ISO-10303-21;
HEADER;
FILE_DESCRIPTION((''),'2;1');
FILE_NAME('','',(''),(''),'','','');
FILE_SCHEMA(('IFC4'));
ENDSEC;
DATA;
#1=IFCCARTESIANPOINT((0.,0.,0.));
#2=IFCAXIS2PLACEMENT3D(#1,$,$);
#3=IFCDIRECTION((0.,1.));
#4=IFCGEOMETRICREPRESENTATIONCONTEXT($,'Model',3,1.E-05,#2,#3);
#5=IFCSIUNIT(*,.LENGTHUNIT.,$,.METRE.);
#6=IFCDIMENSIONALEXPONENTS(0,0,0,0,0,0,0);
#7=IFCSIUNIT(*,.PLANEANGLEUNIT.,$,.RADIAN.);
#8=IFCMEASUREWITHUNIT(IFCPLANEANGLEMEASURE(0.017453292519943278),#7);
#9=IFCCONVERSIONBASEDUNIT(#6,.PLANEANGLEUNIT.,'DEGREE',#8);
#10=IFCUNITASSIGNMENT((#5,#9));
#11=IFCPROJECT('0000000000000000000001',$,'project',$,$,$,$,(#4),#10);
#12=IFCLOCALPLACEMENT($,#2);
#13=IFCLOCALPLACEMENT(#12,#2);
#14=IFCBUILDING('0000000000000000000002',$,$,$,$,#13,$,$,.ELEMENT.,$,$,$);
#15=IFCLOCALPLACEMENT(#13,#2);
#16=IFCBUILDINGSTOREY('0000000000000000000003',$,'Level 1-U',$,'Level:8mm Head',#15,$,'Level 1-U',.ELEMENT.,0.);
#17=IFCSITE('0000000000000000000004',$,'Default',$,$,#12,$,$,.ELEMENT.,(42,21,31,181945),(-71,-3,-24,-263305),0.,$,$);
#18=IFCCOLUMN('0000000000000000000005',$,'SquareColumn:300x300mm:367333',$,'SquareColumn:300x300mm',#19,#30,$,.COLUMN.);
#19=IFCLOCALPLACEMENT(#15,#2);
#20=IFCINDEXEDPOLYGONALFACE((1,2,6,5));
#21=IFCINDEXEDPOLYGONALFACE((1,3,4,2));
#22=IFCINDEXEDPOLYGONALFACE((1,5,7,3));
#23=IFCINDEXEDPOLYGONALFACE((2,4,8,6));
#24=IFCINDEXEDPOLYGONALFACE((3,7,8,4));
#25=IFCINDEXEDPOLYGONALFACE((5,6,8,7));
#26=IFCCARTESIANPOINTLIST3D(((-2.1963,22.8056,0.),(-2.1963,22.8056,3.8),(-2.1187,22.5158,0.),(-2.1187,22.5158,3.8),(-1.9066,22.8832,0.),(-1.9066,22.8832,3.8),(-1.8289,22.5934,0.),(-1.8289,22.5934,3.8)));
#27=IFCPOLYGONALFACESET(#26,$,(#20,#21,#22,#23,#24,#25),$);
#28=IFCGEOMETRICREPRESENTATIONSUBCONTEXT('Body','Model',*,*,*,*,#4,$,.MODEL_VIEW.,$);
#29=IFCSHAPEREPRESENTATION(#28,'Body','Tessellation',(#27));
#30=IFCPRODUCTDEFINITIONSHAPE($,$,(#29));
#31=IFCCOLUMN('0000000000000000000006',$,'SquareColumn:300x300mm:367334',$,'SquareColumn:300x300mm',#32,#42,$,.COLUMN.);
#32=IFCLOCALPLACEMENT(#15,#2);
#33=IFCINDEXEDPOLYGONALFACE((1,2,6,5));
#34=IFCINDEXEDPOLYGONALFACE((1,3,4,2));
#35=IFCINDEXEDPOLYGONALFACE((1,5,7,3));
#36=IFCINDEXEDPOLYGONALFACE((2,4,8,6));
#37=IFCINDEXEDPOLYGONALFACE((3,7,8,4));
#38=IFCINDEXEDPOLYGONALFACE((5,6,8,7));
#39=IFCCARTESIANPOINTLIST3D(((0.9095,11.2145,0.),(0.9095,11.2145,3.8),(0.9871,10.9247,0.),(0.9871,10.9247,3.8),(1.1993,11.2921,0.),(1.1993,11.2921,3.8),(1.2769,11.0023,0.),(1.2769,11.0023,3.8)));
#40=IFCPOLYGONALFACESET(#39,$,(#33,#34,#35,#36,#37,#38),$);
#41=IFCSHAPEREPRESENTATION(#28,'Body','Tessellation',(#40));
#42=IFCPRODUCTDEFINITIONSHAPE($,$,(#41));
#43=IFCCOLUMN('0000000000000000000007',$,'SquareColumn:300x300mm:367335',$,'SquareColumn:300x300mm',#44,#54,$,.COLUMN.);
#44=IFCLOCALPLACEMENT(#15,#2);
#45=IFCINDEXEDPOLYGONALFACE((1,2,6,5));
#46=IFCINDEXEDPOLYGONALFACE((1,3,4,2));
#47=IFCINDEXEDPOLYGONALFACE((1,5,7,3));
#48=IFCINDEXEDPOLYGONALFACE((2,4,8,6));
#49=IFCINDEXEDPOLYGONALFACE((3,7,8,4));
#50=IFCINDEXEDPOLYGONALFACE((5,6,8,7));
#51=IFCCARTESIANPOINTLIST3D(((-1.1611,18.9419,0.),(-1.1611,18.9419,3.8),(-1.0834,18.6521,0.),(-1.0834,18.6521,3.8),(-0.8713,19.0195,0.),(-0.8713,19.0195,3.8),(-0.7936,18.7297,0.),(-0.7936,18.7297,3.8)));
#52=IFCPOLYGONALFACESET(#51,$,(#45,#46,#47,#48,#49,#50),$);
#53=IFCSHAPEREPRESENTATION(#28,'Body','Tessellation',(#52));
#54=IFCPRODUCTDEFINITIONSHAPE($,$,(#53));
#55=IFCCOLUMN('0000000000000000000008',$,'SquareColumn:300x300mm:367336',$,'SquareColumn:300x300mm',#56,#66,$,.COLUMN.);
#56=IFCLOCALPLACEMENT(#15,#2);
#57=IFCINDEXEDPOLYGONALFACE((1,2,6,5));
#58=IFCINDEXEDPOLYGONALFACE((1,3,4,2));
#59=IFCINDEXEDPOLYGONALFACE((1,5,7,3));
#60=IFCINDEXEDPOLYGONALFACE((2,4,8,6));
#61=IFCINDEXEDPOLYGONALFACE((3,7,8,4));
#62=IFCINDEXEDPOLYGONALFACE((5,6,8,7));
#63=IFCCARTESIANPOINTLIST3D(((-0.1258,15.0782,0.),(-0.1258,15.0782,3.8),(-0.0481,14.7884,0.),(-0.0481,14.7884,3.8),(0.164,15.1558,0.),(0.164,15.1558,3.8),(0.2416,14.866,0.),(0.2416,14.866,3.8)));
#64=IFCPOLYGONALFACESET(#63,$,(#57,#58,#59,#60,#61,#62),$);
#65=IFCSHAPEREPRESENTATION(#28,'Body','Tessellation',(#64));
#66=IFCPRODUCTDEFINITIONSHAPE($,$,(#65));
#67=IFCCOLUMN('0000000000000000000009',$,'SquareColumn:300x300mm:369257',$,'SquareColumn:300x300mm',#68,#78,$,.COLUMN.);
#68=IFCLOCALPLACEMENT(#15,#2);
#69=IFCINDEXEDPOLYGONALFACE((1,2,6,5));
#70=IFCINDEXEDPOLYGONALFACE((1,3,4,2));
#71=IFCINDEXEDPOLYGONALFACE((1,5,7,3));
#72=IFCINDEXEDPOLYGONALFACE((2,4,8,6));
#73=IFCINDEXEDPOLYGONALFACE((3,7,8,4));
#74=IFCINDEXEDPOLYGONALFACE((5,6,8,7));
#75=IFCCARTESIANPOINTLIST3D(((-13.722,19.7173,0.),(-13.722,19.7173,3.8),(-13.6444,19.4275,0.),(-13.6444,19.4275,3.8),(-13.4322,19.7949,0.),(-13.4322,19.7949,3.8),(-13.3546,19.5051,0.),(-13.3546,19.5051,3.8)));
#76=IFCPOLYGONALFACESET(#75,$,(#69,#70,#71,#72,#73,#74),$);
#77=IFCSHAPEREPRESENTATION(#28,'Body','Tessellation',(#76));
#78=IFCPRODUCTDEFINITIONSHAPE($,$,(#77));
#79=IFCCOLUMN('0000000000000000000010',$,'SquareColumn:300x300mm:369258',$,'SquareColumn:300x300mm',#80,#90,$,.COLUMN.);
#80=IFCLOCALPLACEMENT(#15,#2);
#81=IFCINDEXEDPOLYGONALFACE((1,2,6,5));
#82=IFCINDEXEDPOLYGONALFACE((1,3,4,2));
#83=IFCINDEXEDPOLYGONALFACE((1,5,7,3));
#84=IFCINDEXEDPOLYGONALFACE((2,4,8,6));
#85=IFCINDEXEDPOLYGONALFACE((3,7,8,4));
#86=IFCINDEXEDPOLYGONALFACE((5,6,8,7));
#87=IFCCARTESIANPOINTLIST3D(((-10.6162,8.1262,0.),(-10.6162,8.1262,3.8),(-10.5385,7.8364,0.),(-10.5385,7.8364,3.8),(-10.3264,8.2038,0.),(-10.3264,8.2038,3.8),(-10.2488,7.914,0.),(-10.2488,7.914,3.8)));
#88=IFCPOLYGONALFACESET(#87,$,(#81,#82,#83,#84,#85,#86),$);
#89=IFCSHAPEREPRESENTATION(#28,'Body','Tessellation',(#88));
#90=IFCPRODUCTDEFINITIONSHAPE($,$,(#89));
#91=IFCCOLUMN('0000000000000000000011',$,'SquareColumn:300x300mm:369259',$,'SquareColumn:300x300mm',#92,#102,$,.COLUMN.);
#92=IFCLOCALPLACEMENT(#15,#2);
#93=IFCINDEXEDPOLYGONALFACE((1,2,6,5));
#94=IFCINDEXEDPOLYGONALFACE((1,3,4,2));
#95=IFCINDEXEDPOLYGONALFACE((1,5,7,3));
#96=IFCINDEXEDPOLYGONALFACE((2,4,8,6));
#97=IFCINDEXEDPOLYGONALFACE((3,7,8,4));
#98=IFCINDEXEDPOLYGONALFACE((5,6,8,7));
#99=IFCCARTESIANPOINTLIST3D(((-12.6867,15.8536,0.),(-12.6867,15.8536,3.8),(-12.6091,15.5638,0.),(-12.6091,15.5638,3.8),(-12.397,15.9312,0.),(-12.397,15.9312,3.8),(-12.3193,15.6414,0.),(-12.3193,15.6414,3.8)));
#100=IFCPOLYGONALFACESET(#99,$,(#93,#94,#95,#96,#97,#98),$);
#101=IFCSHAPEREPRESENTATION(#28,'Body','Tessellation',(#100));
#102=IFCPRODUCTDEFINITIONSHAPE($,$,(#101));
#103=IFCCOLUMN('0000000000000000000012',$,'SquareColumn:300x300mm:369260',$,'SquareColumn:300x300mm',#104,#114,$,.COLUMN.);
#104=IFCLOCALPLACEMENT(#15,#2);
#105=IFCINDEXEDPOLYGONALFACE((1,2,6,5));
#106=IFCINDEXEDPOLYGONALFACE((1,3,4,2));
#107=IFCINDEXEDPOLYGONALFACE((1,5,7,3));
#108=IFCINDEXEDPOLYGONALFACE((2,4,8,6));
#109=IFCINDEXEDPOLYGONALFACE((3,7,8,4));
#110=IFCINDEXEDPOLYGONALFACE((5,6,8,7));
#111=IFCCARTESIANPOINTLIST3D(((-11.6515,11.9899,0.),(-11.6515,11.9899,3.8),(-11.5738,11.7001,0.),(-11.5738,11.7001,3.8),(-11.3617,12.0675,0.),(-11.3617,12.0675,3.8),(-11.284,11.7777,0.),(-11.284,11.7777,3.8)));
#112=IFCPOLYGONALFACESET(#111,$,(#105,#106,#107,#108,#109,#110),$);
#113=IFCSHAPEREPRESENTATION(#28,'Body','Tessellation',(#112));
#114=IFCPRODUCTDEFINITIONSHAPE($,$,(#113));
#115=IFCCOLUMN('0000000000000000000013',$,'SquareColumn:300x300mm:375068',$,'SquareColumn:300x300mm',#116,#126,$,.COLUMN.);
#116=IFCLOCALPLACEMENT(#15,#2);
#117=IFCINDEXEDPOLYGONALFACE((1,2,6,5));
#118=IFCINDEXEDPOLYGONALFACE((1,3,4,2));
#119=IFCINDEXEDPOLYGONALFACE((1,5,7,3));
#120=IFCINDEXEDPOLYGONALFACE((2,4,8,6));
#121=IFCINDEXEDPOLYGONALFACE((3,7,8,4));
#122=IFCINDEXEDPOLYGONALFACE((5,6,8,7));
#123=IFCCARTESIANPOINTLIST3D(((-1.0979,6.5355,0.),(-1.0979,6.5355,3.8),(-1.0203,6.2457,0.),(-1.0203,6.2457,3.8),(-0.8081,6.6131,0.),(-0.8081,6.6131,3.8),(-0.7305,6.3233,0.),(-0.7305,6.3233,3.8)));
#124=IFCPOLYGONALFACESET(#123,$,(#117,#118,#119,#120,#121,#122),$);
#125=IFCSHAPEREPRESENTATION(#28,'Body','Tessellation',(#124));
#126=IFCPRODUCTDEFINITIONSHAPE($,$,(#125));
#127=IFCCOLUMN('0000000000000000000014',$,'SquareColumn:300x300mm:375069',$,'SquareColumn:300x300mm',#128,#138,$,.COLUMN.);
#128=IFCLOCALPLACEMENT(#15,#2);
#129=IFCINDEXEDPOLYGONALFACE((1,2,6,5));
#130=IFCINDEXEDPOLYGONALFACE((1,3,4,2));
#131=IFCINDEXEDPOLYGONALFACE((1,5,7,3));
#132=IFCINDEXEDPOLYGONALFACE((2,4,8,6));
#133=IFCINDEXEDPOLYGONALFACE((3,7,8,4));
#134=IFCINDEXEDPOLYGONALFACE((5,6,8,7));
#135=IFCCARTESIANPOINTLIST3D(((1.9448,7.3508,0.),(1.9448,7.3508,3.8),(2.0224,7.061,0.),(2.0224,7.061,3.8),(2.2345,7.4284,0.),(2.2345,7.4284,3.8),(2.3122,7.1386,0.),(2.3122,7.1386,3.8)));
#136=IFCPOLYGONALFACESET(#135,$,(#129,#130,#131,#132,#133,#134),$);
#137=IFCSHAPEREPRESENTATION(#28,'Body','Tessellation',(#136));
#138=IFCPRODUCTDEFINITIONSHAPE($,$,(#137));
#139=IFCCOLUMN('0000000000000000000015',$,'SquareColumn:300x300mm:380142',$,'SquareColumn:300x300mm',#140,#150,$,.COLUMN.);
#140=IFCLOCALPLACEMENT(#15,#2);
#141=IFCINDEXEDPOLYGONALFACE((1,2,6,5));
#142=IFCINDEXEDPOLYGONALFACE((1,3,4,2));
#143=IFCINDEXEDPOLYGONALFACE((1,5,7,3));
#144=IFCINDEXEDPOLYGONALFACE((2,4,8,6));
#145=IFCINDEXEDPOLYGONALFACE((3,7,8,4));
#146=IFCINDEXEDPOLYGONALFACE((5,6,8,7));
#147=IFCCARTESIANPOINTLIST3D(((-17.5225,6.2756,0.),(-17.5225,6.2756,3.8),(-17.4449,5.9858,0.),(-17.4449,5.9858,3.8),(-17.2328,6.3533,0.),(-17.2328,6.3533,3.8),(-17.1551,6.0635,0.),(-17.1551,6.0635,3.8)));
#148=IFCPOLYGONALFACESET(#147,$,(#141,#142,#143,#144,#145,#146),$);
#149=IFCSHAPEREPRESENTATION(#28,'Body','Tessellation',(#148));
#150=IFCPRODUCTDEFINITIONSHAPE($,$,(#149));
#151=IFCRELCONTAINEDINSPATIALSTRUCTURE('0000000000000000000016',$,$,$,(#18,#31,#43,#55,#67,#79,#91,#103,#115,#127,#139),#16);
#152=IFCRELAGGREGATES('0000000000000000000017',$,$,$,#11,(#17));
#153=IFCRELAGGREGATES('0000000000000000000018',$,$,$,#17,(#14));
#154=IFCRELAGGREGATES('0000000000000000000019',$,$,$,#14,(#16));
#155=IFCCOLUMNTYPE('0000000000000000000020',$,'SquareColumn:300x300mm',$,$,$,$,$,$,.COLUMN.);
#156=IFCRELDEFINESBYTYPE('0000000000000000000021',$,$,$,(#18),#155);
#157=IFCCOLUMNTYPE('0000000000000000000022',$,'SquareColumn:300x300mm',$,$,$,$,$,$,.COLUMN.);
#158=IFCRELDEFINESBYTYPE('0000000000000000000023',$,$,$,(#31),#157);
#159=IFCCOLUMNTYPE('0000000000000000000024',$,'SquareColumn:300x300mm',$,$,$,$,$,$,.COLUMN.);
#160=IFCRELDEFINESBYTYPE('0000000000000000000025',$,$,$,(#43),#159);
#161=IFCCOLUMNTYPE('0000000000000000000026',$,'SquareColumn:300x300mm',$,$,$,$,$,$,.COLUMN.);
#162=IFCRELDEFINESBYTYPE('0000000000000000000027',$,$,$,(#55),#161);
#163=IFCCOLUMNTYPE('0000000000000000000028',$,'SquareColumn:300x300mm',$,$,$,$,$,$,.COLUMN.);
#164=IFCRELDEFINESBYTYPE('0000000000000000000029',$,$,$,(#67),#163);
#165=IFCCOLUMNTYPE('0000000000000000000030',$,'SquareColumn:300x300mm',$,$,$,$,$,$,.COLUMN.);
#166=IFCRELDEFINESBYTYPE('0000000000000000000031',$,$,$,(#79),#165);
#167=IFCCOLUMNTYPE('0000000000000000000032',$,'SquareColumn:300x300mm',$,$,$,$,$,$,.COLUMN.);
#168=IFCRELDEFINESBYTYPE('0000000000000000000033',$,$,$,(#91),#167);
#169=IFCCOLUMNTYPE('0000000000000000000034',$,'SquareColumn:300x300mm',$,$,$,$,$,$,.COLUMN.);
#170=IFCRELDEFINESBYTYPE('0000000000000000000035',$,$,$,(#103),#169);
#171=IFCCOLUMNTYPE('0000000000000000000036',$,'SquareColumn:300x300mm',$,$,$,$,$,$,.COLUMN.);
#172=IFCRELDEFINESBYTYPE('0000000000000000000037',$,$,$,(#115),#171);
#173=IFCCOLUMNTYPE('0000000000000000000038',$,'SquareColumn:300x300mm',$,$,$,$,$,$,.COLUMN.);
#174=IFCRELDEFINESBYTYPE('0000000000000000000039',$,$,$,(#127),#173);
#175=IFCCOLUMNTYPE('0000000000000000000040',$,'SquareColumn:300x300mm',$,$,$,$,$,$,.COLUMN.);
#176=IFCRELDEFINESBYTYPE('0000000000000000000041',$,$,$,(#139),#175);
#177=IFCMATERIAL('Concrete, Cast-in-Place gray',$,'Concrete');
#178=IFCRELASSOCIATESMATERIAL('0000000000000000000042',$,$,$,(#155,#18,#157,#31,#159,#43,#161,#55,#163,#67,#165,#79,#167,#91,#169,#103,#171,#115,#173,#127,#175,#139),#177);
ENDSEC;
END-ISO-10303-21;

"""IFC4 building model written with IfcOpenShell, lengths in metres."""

from ifc_helpers import new_model, entity, si_unit, converted_unit, direction, frame, origin, place, context, subcontext, project, spatial, indexed_curve, outline, extrude, source, transform, mapped, material, type_object, type_shapes, element, save


model = new_model("IFC4")

# Units and contexts
model_context = context("Model", 3, precision=1e-05, world=origin(), true_north=direction((0.0, 1.0)))
body_context = subcontext(model_context, "Body", "Model", "MODEL_VIEW")
ifc_project = project(units=[si_unit("LENGTHUNIT", "METRE"), converted_unit("PLANEANGLEUNIT", "DEGREE", entity("IfcPlaneAngleMeasure", 0.017453292519943278), si_unit("PLANEANGLEUNIT", "RADIAN"), dimensions=[0, 0, 0, 0, 0, 0, 0])], contexts=[model_context])

# Site, building, storey
site_placement = place(None, origin())
site = spatial("IfcSite", under=ifc_project, at=site_placement, Name="Default", CompositionType="ELEMENT", RefLatitude=(42, 21, 31, 181945), RefLongitude=(-71, -3, -24, -263305), RefElevation=0.0)
building_placement = place(site_placement, origin())
building = spatial("IfcBuilding", under=site, at=building_placement, CompositionType="ELEMENT")
storey_placement = place(building_placement, origin())
storey = spatial("IfcBuildingStorey", under=building, at=storey_placement, Name="Level 1-U", ObjectType="Level:8mm Head", LongName="Level 1-U", CompositionType="ELEMENT", Elevation=0.0)

# Columns
ifc_material_1 = material(Name="Concrete, Cast-in-Place gray", Category="Concrete")
column_type_1 = type_object("IfcColumnType", Name="SquareColumn:300x300mm", PredefinedType="COLUMN", material=ifc_material_1)
shared_shape_1 = source(origin(), body_context, "Body", "SweptSolid", [
    extrude(outline(indexed_curve([(-0.15, -0.15), (0.15, -0.15), (0.15, 0.15), (-0.15, 0.15), (-0.15, -0.15)], self_intersect=False)), frame((-2.0126, 22.6995, 0.0), z_axis=(0.0, 0.0, 1.0), x_axis=(-0.258819, 0.965926, 0.0)), (0.0, 0.0, 1.0), 3.8),
])
type_shapes(column_type_1, [shared_shape_1])
column_1_placement = place(storey_placement, origin())
element("IfcColumn", 1, at=column_1_placement, inside=storey, type_object=column_type_1, material=ifc_material_1, Name="SquareColumn:300x300mm:367333", ObjectType="SquareColumn:300x300mm", PredefinedType="COLUMN", context=body_context, shape_type="MappedRepresentation", body=[
    mapped(shared_shape_1, transform((0.0, 0.0, 0.0), scale=1.0)),
])
column_type_2 = type_object("IfcColumnType", Name="SquareColumn:300x300mm", PredefinedType="COLUMN", material=ifc_material_1)
shared_shape_2 = source(origin(), body_context, "Body", "SweptSolid", [
    extrude(outline(indexed_curve([(-0.15, -0.15), (0.15, -0.15), (0.15, 0.15), (-0.15, 0.15), (-0.15, -0.15)], self_intersect=False)), frame((1.0932, 11.1084, 0.0), z_axis=(0.0, 0.0, 1.0), x_axis=(-0.258819, 0.965926, 0.0)), (0.0, 0.0, 1.0), 3.8),
])
type_shapes(column_type_2, [shared_shape_2])
column_2_placement = place(storey_placement, origin())
element("IfcColumn", 2, at=column_2_placement, inside=storey, type_object=column_type_2, material=ifc_material_1, Name="SquareColumn:300x300mm:367334", ObjectType="SquareColumn:300x300mm", PredefinedType="COLUMN", context=body_context, shape_type="MappedRepresentation", body=[
    mapped(shared_shape_2, transform((0.0, 0.0, 0.0), scale=1.0)),
])
column_type_3 = type_object("IfcColumnType", Name="SquareColumn:300x300mm", PredefinedType="COLUMN", material=ifc_material_1)
shared_shape_3 = source(origin(), body_context, "Body", "SweptSolid", [
    extrude(outline(indexed_curve([(-0.15, -0.15), (0.15, -0.15), (0.15, 0.15), (-0.15, 0.15), (-0.15, -0.15)], self_intersect=False)), frame((-0.9774, 18.8358, 0.0), z_axis=(0.0, 0.0, 1.0), x_axis=(-0.258819, 0.965926, 0.0)), (0.0, 0.0, 1.0), 3.8),
])
type_shapes(column_type_3, [shared_shape_3])
column_3_placement = place(storey_placement, origin())
element("IfcColumn", 3, at=column_3_placement, inside=storey, type_object=column_type_3, material=ifc_material_1, Name="SquareColumn:300x300mm:367335", ObjectType="SquareColumn:300x300mm", PredefinedType="COLUMN", context=body_context, shape_type="MappedRepresentation", body=[
    mapped(shared_shape_3, transform((0.0, 0.0, 0.0), scale=1.0)),
])
column_type_4 = type_object("IfcColumnType", Name="SquareColumn:300x300mm", PredefinedType="COLUMN", material=ifc_material_1)
shared_shape_4 = source(origin(), body_context, "Body", "SweptSolid", [
    extrude(outline(indexed_curve([(-0.15, -0.15), (0.15, -0.15), (0.15, 0.15), (-0.15, 0.15), (-0.15, -0.15)], self_intersect=False)), frame((0.0579, 14.9721, 0.0), z_axis=(0.0, 0.0, 1.0), x_axis=(-0.258819, 0.965926, 0.0)), (0.0, 0.0, 1.0), 3.8),
])
type_shapes(column_type_4, [shared_shape_4])
column_4_placement = place(storey_placement, origin())
element("IfcColumn", 4, at=column_4_placement, inside=storey, type_object=column_type_4, material=ifc_material_1, Name="SquareColumn:300x300mm:367336", ObjectType="SquareColumn:300x300mm", PredefinedType="COLUMN", context=body_context, shape_type="MappedRepresentation", body=[
    mapped(shared_shape_4, transform((0.0, 0.0, 0.0), scale=1.0)),
])
column_type_5 = type_object("IfcColumnType", Name="SquareColumn:300x300mm", PredefinedType="COLUMN", material=ifc_material_1)
shared_shape_5 = source(origin(), body_context, "Body", "SweptSolid", [
    extrude(outline(indexed_curve([(-0.15, -0.15), (0.15, -0.15), (0.15, 0.15), (-0.15, 0.15), (-0.15, -0.15)], self_intersect=False)), frame((-13.5383, 19.6112, 0.0), z_axis=(0.0, 0.0, 1.0), x_axis=(-0.258819, 0.965926, 0.0)), (0.0, 0.0, 1.0), 3.8),
])
type_shapes(column_type_5, [shared_shape_5])
column_5_placement = place(storey_placement, origin())
element("IfcColumn", 5, at=column_5_placement, inside=storey, type_object=column_type_5, material=ifc_material_1, Name="SquareColumn:300x300mm:369257", ObjectType="SquareColumn:300x300mm", PredefinedType="COLUMN", context=body_context, shape_type="MappedRepresentation", body=[
    mapped(shared_shape_5, transform((0.0, 0.0, 0.0), scale=1.0)),
])
column_type_6 = type_object("IfcColumnType", Name="SquareColumn:300x300mm", PredefinedType="COLUMN", material=ifc_material_1)
shared_shape_6 = source(origin(), body_context, "Body", "SweptSolid", [
    extrude(outline(indexed_curve([(-0.15, -0.15), (0.15, -0.15), (0.15, 0.15), (-0.15, 0.15), (-0.15, -0.15)], self_intersect=False)), frame((-10.4325, 8.0201, 0.0), z_axis=(0.0, 0.0, 1.0), x_axis=(-0.258819, 0.965926, 0.0)), (0.0, 0.0, 1.0), 3.8),
])
type_shapes(column_type_6, [shared_shape_6])
column_6_placement = place(storey_placement, origin())
element("IfcColumn", 6, at=column_6_placement, inside=storey, type_object=column_type_6, material=ifc_material_1, Name="SquareColumn:300x300mm:369258", ObjectType="SquareColumn:300x300mm", PredefinedType="COLUMN", context=body_context, shape_type="MappedRepresentation", body=[
    mapped(shared_shape_6, transform((0.0, 0.0, 0.0), scale=1.0)),
])
column_type_7 = type_object("IfcColumnType", Name="SquareColumn:300x300mm", PredefinedType="COLUMN", material=ifc_material_1)
shared_shape_7 = source(origin(), body_context, "Body", "SweptSolid", [
    extrude(outline(indexed_curve([(-0.15, -0.15), (0.15, -0.15), (0.15, 0.15), (-0.15, 0.15), (-0.15, -0.15)], self_intersect=False)), frame((-12.503, 15.7475, 0.0), z_axis=(0.0, 0.0, 1.0), x_axis=(-0.258819, 0.965926, 0.0)), (0.0, 0.0, 1.0), 3.8),
])
type_shapes(column_type_7, [shared_shape_7])
column_7_placement = place(storey_placement, origin())
element("IfcColumn", 7, at=column_7_placement, inside=storey, type_object=column_type_7, material=ifc_material_1, Name="SquareColumn:300x300mm:369259", ObjectType="SquareColumn:300x300mm", PredefinedType="COLUMN", context=body_context, shape_type="MappedRepresentation", body=[
    mapped(shared_shape_7, transform((0.0, 0.0, 0.0), scale=1.0)),
])
column_type_8 = type_object("IfcColumnType", Name="SquareColumn:300x300mm", PredefinedType="COLUMN", material=ifc_material_1)
shared_shape_8 = source(origin(), body_context, "Body", "SweptSolid", [
    extrude(outline(indexed_curve([(-0.15, -0.15), (0.15, -0.15), (0.15, 0.15), (-0.15, 0.15), (-0.15, -0.15)], self_intersect=False)), frame((-11.4677, 11.8838, 0.0), z_axis=(0.0, 0.0, 1.0), x_axis=(-0.258819, 0.965926, 0.0)), (0.0, 0.0, 1.0), 3.8),
])
type_shapes(column_type_8, [shared_shape_8])
column_8_placement = place(storey_placement, origin())
element("IfcColumn", 8, at=column_8_placement, inside=storey, type_object=column_type_8, material=ifc_material_1, Name="SquareColumn:300x300mm:369260", ObjectType="SquareColumn:300x300mm", PredefinedType="COLUMN", context=body_context, shape_type="MappedRepresentation", body=[
    mapped(shared_shape_8, transform((0.0, 0.0, 0.0), scale=1.0)),
])
column_type_9 = type_object("IfcColumnType", Name="SquareColumn:300x300mm", PredefinedType="COLUMN", material=ifc_material_1)
shared_shape_9 = source(origin(), body_context, "Body", "SweptSolid", [
    extrude(outline(indexed_curve([(-0.15, -0.15), (0.15, -0.15), (0.15, 0.15), (-0.15, 0.15), (-0.15, -0.15)], self_intersect=False)), frame((-0.9142, 6.4294, 0.0), z_axis=(0.0, 0.0, 1.0), x_axis=(-0.258819, 0.965926, 0.0)), (0.0, 0.0, 1.0), 3.8),
])
type_shapes(column_type_9, [shared_shape_9])
column_9_placement = place(storey_placement, origin())
element("IfcColumn", 9, at=column_9_placement, inside=storey, type_object=column_type_9, material=ifc_material_1, Name="SquareColumn:300x300mm:375068", ObjectType="SquareColumn:300x300mm", PredefinedType="COLUMN", context=body_context, shape_type="MappedRepresentation", body=[
    mapped(shared_shape_9, transform((0.0, 0.0, 0.0), scale=1.0)),
])
column_type_10 = type_object("IfcColumnType", Name="SquareColumn:300x300mm", PredefinedType="COLUMN", material=ifc_material_1)
shared_shape_10 = source(origin(), body_context, "Body", "SweptSolid", [
    extrude(outline(indexed_curve([(-0.15, -0.15), (0.15, -0.15), (0.15, 0.15), (-0.15, 0.15), (-0.15, -0.15)], self_intersect=False)), frame((2.1285, 7.2447, 0.0), z_axis=(0.0, 0.0, 1.0), x_axis=(-0.258819, 0.965926, 0.0)), (0.0, 0.0, 1.0), 3.8),
])
type_shapes(column_type_10, [shared_shape_10])
column_10_placement = place(storey_placement, origin())
element("IfcColumn", 10, at=column_10_placement, inside=storey, type_object=column_type_10, material=ifc_material_1, Name="SquareColumn:300x300mm:375069", ObjectType="SquareColumn:300x300mm", PredefinedType="COLUMN", context=body_context, shape_type="MappedRepresentation", body=[
    mapped(shared_shape_10, transform((0.0, 0.0, 0.0), scale=1.0)),
])
column_type_11 = type_object("IfcColumnType", Name="SquareColumn:300x300mm", PredefinedType="COLUMN", material=ifc_material_1)
shared_shape_11 = source(origin(), body_context, "Body", "SweptSolid", [
    extrude(outline(indexed_curve([(-0.15, -0.15), (0.15, -0.15), (0.15, 0.15), (-0.15, 0.15), (-0.15, -0.15)], self_intersect=False)), frame((-17.3388, 6.1695, 0.0), z_axis=(0.0, 0.0, 1.0), x_axis=(-0.258819, 0.965926, 0.0)), (0.0, 0.0, 1.0), 3.8),
])
type_shapes(column_type_11, [shared_shape_11])
column_11_placement = place(storey_placement, origin())
element("IfcColumn", 11, at=column_11_placement, inside=storey, type_object=column_type_11, material=ifc_material_1, Name="SquareColumn:300x300mm:380142", ObjectType="SquareColumn:300x300mm", PredefinedType="COLUMN", context=body_context, shape_type="MappedRepresentation", body=[
    mapped(shared_shape_11, transform((0.0, 0.0, 0.0), scale=1.0)),
])

save(model, "model.ifc")
